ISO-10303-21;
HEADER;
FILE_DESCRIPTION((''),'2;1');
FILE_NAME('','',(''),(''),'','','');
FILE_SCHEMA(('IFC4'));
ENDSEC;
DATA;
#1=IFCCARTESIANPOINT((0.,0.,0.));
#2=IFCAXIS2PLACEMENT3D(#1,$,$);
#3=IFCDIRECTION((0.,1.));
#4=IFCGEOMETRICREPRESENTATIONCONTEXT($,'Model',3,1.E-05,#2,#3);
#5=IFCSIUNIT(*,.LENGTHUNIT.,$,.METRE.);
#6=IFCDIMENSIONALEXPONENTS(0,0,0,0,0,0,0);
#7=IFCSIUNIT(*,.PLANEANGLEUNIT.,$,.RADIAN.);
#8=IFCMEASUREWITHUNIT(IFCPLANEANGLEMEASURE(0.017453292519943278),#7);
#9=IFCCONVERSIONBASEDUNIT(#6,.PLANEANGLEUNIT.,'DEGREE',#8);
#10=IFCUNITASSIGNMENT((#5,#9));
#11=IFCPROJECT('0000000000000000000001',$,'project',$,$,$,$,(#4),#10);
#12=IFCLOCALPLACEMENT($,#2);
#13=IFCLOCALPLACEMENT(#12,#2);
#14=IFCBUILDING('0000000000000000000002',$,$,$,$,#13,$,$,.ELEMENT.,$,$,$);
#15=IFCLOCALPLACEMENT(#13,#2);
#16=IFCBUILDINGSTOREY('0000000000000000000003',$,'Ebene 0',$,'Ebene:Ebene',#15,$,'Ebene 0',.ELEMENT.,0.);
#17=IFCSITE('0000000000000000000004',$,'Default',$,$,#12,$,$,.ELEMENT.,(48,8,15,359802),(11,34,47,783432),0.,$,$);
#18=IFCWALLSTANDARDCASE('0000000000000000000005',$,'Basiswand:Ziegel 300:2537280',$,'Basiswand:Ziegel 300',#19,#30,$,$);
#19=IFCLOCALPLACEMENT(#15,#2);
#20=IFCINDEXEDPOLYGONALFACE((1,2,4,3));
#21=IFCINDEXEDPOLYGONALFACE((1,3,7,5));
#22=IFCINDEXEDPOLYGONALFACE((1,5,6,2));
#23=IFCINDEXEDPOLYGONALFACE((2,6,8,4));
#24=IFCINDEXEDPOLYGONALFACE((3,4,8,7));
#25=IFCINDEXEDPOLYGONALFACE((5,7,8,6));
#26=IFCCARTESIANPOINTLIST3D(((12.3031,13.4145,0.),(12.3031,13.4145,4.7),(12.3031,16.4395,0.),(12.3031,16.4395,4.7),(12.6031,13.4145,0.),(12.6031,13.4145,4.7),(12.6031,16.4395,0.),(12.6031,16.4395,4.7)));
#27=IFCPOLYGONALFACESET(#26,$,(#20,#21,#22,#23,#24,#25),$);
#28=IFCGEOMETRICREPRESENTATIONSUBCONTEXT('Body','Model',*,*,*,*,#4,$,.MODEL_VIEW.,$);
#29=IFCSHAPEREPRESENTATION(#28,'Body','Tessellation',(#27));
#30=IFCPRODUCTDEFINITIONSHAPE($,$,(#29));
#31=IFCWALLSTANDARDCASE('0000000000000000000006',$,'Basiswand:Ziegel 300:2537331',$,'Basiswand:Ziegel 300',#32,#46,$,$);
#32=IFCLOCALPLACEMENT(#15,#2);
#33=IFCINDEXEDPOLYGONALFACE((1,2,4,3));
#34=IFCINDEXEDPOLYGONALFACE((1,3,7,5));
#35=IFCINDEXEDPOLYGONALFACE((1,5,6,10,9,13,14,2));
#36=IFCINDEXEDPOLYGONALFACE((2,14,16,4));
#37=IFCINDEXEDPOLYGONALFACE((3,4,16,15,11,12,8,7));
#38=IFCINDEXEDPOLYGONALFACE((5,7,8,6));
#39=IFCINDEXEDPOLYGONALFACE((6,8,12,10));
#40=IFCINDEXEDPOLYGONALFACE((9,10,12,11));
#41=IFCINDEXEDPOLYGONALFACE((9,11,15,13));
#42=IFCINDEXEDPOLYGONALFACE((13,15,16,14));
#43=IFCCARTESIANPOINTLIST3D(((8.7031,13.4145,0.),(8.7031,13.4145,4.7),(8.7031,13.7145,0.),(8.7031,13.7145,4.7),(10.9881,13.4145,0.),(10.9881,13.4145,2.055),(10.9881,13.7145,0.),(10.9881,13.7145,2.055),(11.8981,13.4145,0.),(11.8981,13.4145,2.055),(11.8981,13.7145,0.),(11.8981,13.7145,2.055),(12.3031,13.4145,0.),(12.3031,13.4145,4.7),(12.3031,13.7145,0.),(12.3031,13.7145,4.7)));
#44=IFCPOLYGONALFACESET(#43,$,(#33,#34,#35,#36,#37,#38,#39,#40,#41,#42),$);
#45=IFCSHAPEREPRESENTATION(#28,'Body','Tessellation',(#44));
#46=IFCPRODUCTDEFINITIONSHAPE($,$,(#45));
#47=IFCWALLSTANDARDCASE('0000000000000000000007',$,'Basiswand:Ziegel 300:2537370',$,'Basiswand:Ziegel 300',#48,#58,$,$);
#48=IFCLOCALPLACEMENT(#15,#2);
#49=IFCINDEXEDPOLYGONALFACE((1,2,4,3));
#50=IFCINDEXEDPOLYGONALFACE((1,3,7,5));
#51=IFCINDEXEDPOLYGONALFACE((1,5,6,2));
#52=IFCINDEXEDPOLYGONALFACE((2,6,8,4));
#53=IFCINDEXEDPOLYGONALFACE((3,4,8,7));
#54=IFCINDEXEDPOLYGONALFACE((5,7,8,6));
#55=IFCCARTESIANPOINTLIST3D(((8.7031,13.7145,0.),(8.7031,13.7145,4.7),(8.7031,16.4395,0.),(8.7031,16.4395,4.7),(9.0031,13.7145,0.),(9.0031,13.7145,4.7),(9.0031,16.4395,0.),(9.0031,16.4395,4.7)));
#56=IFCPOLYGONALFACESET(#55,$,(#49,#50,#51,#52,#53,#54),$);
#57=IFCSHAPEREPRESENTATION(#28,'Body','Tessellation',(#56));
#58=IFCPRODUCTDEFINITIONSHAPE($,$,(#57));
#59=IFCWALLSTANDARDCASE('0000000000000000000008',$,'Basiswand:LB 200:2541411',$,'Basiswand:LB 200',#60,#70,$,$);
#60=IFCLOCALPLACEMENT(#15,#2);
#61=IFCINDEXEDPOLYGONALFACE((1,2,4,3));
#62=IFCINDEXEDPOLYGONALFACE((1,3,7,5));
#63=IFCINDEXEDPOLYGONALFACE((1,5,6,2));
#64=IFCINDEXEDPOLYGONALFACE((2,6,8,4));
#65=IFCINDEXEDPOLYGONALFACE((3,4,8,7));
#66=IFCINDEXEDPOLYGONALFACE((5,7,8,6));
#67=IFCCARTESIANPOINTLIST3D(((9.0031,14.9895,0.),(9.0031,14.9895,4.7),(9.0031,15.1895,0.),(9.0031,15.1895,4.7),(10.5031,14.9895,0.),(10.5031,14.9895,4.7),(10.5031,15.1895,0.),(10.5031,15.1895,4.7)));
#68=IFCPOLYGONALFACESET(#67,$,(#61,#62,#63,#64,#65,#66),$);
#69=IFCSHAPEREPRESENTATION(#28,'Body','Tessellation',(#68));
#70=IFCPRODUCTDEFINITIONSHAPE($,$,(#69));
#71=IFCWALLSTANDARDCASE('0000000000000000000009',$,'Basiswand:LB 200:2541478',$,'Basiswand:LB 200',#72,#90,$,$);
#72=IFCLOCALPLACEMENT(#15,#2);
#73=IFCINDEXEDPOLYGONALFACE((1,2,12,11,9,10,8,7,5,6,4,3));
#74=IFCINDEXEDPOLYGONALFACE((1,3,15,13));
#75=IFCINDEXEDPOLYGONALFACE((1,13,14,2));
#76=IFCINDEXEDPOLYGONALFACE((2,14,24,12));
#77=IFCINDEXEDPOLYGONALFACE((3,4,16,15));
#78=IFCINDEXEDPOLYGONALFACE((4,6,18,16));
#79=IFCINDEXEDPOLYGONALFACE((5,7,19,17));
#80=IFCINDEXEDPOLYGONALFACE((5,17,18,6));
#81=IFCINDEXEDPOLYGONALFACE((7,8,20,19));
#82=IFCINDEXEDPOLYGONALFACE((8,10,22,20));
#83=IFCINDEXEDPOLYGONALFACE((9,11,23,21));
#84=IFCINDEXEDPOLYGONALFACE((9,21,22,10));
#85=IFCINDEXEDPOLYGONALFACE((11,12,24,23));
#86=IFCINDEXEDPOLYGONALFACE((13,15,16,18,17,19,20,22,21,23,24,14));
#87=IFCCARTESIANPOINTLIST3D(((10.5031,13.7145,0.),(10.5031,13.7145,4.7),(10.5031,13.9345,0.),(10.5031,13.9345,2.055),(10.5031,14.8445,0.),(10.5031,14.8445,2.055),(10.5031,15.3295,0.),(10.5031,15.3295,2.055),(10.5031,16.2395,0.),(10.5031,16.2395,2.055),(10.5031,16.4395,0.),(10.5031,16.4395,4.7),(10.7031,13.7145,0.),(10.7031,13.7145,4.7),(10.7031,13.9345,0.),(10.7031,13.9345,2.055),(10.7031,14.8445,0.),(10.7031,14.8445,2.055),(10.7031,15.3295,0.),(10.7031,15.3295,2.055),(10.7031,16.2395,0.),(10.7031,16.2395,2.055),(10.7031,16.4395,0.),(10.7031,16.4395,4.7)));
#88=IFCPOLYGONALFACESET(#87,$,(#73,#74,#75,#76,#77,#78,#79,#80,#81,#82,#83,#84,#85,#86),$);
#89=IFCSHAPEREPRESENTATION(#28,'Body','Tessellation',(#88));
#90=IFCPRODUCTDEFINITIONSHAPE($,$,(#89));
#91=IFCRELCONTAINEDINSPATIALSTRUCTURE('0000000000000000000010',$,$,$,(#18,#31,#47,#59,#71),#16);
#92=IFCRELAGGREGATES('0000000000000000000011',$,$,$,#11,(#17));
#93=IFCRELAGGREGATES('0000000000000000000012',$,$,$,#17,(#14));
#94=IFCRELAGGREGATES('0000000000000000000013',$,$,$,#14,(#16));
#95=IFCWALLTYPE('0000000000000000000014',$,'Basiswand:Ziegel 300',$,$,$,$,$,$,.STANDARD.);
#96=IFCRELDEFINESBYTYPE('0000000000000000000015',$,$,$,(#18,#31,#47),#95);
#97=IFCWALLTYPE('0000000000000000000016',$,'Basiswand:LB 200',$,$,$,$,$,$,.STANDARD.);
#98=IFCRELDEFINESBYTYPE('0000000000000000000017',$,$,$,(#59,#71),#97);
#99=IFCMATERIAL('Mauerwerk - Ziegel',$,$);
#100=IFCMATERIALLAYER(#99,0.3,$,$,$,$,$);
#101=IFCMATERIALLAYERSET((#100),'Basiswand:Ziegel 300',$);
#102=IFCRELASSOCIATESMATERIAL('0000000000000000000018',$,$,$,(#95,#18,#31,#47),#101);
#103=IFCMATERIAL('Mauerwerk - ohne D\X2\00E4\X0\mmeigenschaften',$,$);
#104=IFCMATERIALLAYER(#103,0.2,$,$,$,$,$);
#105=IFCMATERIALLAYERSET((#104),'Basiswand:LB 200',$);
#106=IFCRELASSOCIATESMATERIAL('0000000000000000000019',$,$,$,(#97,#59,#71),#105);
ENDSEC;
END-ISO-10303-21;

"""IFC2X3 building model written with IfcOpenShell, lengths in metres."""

from ifc_helpers import new_model, entity, si_unit, converted_unit, direction, frame, frame_2d, origin, place, context, subcontext, project, spatial, polyline, rectangle, extrude, clip, bounded_halfspace, material, layer, layer_set, layer_usage, type_object, element, save


model = new_model("IFC2X3")

# Units and contexts
model_context = context("Model", 3, precision=1e-05, world=origin(), true_north=direction((0.0, 1.0)))
body_context = subcontext(model_context, "Body", "Model", "MODEL_VIEW")
ifc_project = project(units=[si_unit("LENGTHUNIT", "METRE"), converted_unit("PLANEANGLEUNIT", "DEGREE", entity("IfcPlaneAngleMeasure", 0.017453292519943278), si_unit("PLANEANGLEUNIT", "RADIAN"), dimensions=[0, 0, 0, 0, 0, 0, 0])], contexts=[model_context])

# Site, building, storey
site_placement = place(None, origin())
site = spatial("IfcSite", under=ifc_project, at=site_placement, Name="Default", CompositionType="ELEMENT", RefLatitude=(48, 8, 15, 359802), RefLongitude=(11, 34, 47, 783432), RefElevation=0.0)
building_placement = place(site_placement, origin())
building = spatial("IfcBuilding", under=site, at=building_placement, CompositionType="ELEMENT")
storey_placement = place(building_placement, origin())
storey = spatial("IfcBuildingStorey", under=building, at=storey_placement, Name="Ebene 0", ObjectType="Ebene:Ebene", LongName="Ebene 0", CompositionType="ELEMENT", Elevation=0.0)

# Wall
ifc_material_1 = material(Name="Mauerwerk - Ziegel")
ifc_layer_1 = layer(ifc_material_1, 0.3)
ifc_layer_set_1 = layer_set([ifc_layer_1], Name="Basiswand:Ziegel 300")
ifc_layer_usage_1 = layer_usage(ifc_layer_set_1, "AXIS2", "NEGATIVE", 0.15)
wall_type_1 = type_object("IfcWallType", Name="Basiswand:Ziegel 300", PredefinedType="STANDARD", material=ifc_layer_set_1)
wall_1_placement = place(storey_placement, frame((12.4531, 16.4395, 0.0), z_axis=(0.0, 0.0, 1.0), x_axis=(0.0, -1.0, 0.0)))
element("IfcWallStandardCase", 1, at=wall_1_placement, inside=storey, type_object=wall_type_1, material=ifc_layer_usage_1, Name="Basiswand:Ziegel 300:2537280", ObjectType="Basiswand:Ziegel 300", context=body_context, shape_type="Clipping", body=[
    clip(extrude(rectangle(XDim=3.025, YDim=0.3, at=frame_2d((1.5125, 0.0), x_axis=(-1.0, 0.0))), origin(), (0.0, 0.0, 1.0), 4.7), bounded_halfspace(frame((0.0, -0.15, 4.7), z_axis=(0.0, 0.0, -1.0), x_axis=(1.0, 0.0, 0.0)), True, frame((0.0, -0.15, 4.7)), polyline([(0.0, 0.0), (2.725, 0.0), (3.025, 0.0), (3.025, 0.3), (0.0, 0.3), (0.0, 0.0)]))),
])

# Wall, opening
ifc_layer_usage_2 = layer_usage(ifc_layer_set_1, "AXIS2", "NEGATIVE", 0.15)
wall_2_placement = place(storey_placement, frame((12.3031, 13.5645, 0.0), z_axis=(0.0, 0.0, 1.0), x_axis=(-1.0, 0.0, 0.0)))
wall_2 = element("IfcWallStandardCase", 2, at=wall_2_placement, inside=storey, type_object=wall_type_1, material=ifc_layer_usage_2, Name="Basiswand:Ziegel 300:2537331", ObjectType="Basiswand:Ziegel 300", context=body_context, shape_type="Clipping", body=[
    clip(extrude(rectangle(XDim=3.6, YDim=0.3, at=frame_2d((1.8, 0.0), x_axis=(-1.0, 0.0))), origin(), (0.0, 0.0, 1.0), 4.7), bounded_halfspace(frame((0.0, -0.15, 4.7), z_axis=(0.0, 0.0, -1.0), x_axis=(0.0, 1.0, 0.0)), True, frame((0.0, -0.15, 4.7)), polyline([(0.0, 0.0), (3.3, 0.0), (3.6, 0.0), (3.6, 0.3), (0.0, 0.3), (0.0, 0.0)]))),
])
opening_1_placement = place(wall_2_placement, frame((1.315, 0.15, -0.18)))
element("IfcOpeningElement", 3, at=opening_1_placement, cuts=wall_2, ObjectType="Opening", context=body_context, shape_type="SweptSolid", body=[
    extrude(rectangle(XDim=2.235, YDim=0.91, at=frame_2d((1.1175, 0.455), x_axis=(-1.0, 0.0))), frame((0.0, 0.0, 0.0), z_axis=(0.0, -1.0, 0.0), x_axis=(0.0, 0.0, 1.0)), (0.0, 0.0, 1.0), 0.3),
])

# Walls
ifc_layer_usage_3 = layer_usage(ifc_layer_set_1, "AXIS2", "NEGATIVE", 0.15)
wall_3_placement = place(storey_placement, frame((8.8531, 13.7145, 0.0), z_axis=(0.0, 0.0, 1.0), x_axis=(0.0, 1.0, 0.0)))
element("IfcWallStandardCase", 4, at=wall_3_placement, inside=storey, type_object=wall_type_1, material=ifc_layer_usage_3, Name="Basiswand:Ziegel 300:2537370", ObjectType="Basiswand:Ziegel 300", context=body_context, shape_type="Clipping", body=[
    clip(extrude(rectangle(XDim=2.725, YDim=0.3, at=frame_2d((1.3625, 0.0), x_axis=(-1.0, 0.0))), origin(), (0.0, 0.0, 1.0), 4.7), bounded_halfspace(frame((0.0, -0.15, 4.7), z_axis=(0.0, 0.0, -1.0), x_axis=(-1.0, 0.0, 0.0)), True, frame((0.0, -0.15, 4.7)), polyline([(0.0, 0.0), (2.725, 0.0), (2.725, 0.3), (0.0, 0.3), (0.0, 0.0)]))),
])
ifc_material_2 = material(Name="Mauerwerk - ohne Dämmeigenschaften")
ifc_layer_2 = layer(ifc_material_2, 0.2)
ifc_layer_set_2 = layer_set([ifc_layer_2], Name="Basiswand:LB 200")
ifc_layer_usage_4 = layer_usage(ifc_layer_set_2, "AXIS2", "NEGATIVE", 0.1)
wall_type_2 = type_object("IfcWallType", Name="Basiswand:LB 200", PredefinedType="STANDARD", material=ifc_layer_set_2)
wall_4_placement = place(storey_placement, frame((9.0031, 15.0895, 0.0)))
element("IfcWallStandardCase", 5, at=wall_4_placement, inside=storey, type_object=wall_type_2, material=ifc_layer_usage_4, Name="Basiswand:LB 200:2541411", ObjectType="Basiswand:LB 200", context=body_context, shape_type="Clipping", body=[
    clip(extrude(rectangle(XDim=1.5, YDim=0.2, at=frame_2d((0.75, 0.0), x_axis=(-1.0, 0.0))), origin(), (0.0, 0.0, 1.0), 4.7), bounded_halfspace(frame((0.0, -0.1, 4.7), z_axis=(0.0, 0.0, -1.0), x_axis=(0.0, -1.0, 0.0)), True, frame((0.0, -0.1, 4.7)), polyline([(0.0, 0.0), (1.5, 0.0), (1.5, 0.2), (0.0, 0.2), (0.0, 0.0)]))),
])

# Wall, openings
ifc_layer_usage_5 = layer_usage(ifc_layer_set_2, "AXIS2", "NEGATIVE", 0.1)
wall_5_placement = place(storey_placement, frame((10.6031, 16.4395, 0.0), z_axis=(0.0, 0.0, 1.0), x_axis=(0.0, -1.0, 0.0)))
wall_5 = element("IfcWallStandardCase", 6, at=wall_5_placement, inside=storey, type_object=wall_type_2, material=ifc_layer_usage_5, Name="Basiswand:LB 200:2541478", ObjectType="Basiswand:LB 200", context=body_context, shape_type="Clipping", body=[
    clip(extrude(rectangle(XDim=2.725, YDim=0.2, at=frame_2d((1.3625, 0.0), x_axis=(1.0, 0.0))), origin(), (0.0, 0.0, 1.0), 4.7), bounded_halfspace(frame((0.0, -0.1, 4.7), z_axis=(0.0, 0.0, -1.0), x_axis=(1.0, 0.0, 0.0)), True, frame((0.0, -0.1, 4.7)), polyline([(0.0, 0.0), (1.25, 0.0), (1.45, 0.0), (2.725, 0.0), (2.725, 0.2), (0.0, 0.2), (0.0, 0.0)]))),
])
opening_2_placement = place(wall_5_placement, frame((1.11, 0.1, -0.18)))
element("IfcOpeningElement", 7, at=opening_2_placement, cuts=wall_5, ObjectType="Opening", context=body_context, shape_type="SweptSolid", body=[
    extrude(rectangle(XDim=2.235, YDim=0.91, at=frame_2d((1.1175, 0.455), x_axis=(-1.0, 0.0))), frame((0.0, 0.0, 0.0), z_axis=(0.0, -1.0, 0.0), x_axis=(0.0, 0.0, 1.0)), (0.0, 0.0, 1.0), 0.2),
])
opening_3_placement = place(wall_5_placement, frame((2.505, 0.1, -0.18)))
element("IfcOpeningElement", 8, at=opening_3_placement, cuts=wall_5, ObjectType="Opening", context=body_context, shape_type="SweptSolid", body=[
    extrude(rectangle(XDim=2.235, YDim=0.91, at=frame_2d((1.1175, 0.455), x_axis=(-1.0, 0.0))), frame((0.0, 0.0, 0.0), z_axis=(0.0, -1.0, 0.0), x_axis=(0.0, 0.0, 1.0)), (0.0, 0.0, 1.0), 0.2),
])

save(model, "model.ifc")
